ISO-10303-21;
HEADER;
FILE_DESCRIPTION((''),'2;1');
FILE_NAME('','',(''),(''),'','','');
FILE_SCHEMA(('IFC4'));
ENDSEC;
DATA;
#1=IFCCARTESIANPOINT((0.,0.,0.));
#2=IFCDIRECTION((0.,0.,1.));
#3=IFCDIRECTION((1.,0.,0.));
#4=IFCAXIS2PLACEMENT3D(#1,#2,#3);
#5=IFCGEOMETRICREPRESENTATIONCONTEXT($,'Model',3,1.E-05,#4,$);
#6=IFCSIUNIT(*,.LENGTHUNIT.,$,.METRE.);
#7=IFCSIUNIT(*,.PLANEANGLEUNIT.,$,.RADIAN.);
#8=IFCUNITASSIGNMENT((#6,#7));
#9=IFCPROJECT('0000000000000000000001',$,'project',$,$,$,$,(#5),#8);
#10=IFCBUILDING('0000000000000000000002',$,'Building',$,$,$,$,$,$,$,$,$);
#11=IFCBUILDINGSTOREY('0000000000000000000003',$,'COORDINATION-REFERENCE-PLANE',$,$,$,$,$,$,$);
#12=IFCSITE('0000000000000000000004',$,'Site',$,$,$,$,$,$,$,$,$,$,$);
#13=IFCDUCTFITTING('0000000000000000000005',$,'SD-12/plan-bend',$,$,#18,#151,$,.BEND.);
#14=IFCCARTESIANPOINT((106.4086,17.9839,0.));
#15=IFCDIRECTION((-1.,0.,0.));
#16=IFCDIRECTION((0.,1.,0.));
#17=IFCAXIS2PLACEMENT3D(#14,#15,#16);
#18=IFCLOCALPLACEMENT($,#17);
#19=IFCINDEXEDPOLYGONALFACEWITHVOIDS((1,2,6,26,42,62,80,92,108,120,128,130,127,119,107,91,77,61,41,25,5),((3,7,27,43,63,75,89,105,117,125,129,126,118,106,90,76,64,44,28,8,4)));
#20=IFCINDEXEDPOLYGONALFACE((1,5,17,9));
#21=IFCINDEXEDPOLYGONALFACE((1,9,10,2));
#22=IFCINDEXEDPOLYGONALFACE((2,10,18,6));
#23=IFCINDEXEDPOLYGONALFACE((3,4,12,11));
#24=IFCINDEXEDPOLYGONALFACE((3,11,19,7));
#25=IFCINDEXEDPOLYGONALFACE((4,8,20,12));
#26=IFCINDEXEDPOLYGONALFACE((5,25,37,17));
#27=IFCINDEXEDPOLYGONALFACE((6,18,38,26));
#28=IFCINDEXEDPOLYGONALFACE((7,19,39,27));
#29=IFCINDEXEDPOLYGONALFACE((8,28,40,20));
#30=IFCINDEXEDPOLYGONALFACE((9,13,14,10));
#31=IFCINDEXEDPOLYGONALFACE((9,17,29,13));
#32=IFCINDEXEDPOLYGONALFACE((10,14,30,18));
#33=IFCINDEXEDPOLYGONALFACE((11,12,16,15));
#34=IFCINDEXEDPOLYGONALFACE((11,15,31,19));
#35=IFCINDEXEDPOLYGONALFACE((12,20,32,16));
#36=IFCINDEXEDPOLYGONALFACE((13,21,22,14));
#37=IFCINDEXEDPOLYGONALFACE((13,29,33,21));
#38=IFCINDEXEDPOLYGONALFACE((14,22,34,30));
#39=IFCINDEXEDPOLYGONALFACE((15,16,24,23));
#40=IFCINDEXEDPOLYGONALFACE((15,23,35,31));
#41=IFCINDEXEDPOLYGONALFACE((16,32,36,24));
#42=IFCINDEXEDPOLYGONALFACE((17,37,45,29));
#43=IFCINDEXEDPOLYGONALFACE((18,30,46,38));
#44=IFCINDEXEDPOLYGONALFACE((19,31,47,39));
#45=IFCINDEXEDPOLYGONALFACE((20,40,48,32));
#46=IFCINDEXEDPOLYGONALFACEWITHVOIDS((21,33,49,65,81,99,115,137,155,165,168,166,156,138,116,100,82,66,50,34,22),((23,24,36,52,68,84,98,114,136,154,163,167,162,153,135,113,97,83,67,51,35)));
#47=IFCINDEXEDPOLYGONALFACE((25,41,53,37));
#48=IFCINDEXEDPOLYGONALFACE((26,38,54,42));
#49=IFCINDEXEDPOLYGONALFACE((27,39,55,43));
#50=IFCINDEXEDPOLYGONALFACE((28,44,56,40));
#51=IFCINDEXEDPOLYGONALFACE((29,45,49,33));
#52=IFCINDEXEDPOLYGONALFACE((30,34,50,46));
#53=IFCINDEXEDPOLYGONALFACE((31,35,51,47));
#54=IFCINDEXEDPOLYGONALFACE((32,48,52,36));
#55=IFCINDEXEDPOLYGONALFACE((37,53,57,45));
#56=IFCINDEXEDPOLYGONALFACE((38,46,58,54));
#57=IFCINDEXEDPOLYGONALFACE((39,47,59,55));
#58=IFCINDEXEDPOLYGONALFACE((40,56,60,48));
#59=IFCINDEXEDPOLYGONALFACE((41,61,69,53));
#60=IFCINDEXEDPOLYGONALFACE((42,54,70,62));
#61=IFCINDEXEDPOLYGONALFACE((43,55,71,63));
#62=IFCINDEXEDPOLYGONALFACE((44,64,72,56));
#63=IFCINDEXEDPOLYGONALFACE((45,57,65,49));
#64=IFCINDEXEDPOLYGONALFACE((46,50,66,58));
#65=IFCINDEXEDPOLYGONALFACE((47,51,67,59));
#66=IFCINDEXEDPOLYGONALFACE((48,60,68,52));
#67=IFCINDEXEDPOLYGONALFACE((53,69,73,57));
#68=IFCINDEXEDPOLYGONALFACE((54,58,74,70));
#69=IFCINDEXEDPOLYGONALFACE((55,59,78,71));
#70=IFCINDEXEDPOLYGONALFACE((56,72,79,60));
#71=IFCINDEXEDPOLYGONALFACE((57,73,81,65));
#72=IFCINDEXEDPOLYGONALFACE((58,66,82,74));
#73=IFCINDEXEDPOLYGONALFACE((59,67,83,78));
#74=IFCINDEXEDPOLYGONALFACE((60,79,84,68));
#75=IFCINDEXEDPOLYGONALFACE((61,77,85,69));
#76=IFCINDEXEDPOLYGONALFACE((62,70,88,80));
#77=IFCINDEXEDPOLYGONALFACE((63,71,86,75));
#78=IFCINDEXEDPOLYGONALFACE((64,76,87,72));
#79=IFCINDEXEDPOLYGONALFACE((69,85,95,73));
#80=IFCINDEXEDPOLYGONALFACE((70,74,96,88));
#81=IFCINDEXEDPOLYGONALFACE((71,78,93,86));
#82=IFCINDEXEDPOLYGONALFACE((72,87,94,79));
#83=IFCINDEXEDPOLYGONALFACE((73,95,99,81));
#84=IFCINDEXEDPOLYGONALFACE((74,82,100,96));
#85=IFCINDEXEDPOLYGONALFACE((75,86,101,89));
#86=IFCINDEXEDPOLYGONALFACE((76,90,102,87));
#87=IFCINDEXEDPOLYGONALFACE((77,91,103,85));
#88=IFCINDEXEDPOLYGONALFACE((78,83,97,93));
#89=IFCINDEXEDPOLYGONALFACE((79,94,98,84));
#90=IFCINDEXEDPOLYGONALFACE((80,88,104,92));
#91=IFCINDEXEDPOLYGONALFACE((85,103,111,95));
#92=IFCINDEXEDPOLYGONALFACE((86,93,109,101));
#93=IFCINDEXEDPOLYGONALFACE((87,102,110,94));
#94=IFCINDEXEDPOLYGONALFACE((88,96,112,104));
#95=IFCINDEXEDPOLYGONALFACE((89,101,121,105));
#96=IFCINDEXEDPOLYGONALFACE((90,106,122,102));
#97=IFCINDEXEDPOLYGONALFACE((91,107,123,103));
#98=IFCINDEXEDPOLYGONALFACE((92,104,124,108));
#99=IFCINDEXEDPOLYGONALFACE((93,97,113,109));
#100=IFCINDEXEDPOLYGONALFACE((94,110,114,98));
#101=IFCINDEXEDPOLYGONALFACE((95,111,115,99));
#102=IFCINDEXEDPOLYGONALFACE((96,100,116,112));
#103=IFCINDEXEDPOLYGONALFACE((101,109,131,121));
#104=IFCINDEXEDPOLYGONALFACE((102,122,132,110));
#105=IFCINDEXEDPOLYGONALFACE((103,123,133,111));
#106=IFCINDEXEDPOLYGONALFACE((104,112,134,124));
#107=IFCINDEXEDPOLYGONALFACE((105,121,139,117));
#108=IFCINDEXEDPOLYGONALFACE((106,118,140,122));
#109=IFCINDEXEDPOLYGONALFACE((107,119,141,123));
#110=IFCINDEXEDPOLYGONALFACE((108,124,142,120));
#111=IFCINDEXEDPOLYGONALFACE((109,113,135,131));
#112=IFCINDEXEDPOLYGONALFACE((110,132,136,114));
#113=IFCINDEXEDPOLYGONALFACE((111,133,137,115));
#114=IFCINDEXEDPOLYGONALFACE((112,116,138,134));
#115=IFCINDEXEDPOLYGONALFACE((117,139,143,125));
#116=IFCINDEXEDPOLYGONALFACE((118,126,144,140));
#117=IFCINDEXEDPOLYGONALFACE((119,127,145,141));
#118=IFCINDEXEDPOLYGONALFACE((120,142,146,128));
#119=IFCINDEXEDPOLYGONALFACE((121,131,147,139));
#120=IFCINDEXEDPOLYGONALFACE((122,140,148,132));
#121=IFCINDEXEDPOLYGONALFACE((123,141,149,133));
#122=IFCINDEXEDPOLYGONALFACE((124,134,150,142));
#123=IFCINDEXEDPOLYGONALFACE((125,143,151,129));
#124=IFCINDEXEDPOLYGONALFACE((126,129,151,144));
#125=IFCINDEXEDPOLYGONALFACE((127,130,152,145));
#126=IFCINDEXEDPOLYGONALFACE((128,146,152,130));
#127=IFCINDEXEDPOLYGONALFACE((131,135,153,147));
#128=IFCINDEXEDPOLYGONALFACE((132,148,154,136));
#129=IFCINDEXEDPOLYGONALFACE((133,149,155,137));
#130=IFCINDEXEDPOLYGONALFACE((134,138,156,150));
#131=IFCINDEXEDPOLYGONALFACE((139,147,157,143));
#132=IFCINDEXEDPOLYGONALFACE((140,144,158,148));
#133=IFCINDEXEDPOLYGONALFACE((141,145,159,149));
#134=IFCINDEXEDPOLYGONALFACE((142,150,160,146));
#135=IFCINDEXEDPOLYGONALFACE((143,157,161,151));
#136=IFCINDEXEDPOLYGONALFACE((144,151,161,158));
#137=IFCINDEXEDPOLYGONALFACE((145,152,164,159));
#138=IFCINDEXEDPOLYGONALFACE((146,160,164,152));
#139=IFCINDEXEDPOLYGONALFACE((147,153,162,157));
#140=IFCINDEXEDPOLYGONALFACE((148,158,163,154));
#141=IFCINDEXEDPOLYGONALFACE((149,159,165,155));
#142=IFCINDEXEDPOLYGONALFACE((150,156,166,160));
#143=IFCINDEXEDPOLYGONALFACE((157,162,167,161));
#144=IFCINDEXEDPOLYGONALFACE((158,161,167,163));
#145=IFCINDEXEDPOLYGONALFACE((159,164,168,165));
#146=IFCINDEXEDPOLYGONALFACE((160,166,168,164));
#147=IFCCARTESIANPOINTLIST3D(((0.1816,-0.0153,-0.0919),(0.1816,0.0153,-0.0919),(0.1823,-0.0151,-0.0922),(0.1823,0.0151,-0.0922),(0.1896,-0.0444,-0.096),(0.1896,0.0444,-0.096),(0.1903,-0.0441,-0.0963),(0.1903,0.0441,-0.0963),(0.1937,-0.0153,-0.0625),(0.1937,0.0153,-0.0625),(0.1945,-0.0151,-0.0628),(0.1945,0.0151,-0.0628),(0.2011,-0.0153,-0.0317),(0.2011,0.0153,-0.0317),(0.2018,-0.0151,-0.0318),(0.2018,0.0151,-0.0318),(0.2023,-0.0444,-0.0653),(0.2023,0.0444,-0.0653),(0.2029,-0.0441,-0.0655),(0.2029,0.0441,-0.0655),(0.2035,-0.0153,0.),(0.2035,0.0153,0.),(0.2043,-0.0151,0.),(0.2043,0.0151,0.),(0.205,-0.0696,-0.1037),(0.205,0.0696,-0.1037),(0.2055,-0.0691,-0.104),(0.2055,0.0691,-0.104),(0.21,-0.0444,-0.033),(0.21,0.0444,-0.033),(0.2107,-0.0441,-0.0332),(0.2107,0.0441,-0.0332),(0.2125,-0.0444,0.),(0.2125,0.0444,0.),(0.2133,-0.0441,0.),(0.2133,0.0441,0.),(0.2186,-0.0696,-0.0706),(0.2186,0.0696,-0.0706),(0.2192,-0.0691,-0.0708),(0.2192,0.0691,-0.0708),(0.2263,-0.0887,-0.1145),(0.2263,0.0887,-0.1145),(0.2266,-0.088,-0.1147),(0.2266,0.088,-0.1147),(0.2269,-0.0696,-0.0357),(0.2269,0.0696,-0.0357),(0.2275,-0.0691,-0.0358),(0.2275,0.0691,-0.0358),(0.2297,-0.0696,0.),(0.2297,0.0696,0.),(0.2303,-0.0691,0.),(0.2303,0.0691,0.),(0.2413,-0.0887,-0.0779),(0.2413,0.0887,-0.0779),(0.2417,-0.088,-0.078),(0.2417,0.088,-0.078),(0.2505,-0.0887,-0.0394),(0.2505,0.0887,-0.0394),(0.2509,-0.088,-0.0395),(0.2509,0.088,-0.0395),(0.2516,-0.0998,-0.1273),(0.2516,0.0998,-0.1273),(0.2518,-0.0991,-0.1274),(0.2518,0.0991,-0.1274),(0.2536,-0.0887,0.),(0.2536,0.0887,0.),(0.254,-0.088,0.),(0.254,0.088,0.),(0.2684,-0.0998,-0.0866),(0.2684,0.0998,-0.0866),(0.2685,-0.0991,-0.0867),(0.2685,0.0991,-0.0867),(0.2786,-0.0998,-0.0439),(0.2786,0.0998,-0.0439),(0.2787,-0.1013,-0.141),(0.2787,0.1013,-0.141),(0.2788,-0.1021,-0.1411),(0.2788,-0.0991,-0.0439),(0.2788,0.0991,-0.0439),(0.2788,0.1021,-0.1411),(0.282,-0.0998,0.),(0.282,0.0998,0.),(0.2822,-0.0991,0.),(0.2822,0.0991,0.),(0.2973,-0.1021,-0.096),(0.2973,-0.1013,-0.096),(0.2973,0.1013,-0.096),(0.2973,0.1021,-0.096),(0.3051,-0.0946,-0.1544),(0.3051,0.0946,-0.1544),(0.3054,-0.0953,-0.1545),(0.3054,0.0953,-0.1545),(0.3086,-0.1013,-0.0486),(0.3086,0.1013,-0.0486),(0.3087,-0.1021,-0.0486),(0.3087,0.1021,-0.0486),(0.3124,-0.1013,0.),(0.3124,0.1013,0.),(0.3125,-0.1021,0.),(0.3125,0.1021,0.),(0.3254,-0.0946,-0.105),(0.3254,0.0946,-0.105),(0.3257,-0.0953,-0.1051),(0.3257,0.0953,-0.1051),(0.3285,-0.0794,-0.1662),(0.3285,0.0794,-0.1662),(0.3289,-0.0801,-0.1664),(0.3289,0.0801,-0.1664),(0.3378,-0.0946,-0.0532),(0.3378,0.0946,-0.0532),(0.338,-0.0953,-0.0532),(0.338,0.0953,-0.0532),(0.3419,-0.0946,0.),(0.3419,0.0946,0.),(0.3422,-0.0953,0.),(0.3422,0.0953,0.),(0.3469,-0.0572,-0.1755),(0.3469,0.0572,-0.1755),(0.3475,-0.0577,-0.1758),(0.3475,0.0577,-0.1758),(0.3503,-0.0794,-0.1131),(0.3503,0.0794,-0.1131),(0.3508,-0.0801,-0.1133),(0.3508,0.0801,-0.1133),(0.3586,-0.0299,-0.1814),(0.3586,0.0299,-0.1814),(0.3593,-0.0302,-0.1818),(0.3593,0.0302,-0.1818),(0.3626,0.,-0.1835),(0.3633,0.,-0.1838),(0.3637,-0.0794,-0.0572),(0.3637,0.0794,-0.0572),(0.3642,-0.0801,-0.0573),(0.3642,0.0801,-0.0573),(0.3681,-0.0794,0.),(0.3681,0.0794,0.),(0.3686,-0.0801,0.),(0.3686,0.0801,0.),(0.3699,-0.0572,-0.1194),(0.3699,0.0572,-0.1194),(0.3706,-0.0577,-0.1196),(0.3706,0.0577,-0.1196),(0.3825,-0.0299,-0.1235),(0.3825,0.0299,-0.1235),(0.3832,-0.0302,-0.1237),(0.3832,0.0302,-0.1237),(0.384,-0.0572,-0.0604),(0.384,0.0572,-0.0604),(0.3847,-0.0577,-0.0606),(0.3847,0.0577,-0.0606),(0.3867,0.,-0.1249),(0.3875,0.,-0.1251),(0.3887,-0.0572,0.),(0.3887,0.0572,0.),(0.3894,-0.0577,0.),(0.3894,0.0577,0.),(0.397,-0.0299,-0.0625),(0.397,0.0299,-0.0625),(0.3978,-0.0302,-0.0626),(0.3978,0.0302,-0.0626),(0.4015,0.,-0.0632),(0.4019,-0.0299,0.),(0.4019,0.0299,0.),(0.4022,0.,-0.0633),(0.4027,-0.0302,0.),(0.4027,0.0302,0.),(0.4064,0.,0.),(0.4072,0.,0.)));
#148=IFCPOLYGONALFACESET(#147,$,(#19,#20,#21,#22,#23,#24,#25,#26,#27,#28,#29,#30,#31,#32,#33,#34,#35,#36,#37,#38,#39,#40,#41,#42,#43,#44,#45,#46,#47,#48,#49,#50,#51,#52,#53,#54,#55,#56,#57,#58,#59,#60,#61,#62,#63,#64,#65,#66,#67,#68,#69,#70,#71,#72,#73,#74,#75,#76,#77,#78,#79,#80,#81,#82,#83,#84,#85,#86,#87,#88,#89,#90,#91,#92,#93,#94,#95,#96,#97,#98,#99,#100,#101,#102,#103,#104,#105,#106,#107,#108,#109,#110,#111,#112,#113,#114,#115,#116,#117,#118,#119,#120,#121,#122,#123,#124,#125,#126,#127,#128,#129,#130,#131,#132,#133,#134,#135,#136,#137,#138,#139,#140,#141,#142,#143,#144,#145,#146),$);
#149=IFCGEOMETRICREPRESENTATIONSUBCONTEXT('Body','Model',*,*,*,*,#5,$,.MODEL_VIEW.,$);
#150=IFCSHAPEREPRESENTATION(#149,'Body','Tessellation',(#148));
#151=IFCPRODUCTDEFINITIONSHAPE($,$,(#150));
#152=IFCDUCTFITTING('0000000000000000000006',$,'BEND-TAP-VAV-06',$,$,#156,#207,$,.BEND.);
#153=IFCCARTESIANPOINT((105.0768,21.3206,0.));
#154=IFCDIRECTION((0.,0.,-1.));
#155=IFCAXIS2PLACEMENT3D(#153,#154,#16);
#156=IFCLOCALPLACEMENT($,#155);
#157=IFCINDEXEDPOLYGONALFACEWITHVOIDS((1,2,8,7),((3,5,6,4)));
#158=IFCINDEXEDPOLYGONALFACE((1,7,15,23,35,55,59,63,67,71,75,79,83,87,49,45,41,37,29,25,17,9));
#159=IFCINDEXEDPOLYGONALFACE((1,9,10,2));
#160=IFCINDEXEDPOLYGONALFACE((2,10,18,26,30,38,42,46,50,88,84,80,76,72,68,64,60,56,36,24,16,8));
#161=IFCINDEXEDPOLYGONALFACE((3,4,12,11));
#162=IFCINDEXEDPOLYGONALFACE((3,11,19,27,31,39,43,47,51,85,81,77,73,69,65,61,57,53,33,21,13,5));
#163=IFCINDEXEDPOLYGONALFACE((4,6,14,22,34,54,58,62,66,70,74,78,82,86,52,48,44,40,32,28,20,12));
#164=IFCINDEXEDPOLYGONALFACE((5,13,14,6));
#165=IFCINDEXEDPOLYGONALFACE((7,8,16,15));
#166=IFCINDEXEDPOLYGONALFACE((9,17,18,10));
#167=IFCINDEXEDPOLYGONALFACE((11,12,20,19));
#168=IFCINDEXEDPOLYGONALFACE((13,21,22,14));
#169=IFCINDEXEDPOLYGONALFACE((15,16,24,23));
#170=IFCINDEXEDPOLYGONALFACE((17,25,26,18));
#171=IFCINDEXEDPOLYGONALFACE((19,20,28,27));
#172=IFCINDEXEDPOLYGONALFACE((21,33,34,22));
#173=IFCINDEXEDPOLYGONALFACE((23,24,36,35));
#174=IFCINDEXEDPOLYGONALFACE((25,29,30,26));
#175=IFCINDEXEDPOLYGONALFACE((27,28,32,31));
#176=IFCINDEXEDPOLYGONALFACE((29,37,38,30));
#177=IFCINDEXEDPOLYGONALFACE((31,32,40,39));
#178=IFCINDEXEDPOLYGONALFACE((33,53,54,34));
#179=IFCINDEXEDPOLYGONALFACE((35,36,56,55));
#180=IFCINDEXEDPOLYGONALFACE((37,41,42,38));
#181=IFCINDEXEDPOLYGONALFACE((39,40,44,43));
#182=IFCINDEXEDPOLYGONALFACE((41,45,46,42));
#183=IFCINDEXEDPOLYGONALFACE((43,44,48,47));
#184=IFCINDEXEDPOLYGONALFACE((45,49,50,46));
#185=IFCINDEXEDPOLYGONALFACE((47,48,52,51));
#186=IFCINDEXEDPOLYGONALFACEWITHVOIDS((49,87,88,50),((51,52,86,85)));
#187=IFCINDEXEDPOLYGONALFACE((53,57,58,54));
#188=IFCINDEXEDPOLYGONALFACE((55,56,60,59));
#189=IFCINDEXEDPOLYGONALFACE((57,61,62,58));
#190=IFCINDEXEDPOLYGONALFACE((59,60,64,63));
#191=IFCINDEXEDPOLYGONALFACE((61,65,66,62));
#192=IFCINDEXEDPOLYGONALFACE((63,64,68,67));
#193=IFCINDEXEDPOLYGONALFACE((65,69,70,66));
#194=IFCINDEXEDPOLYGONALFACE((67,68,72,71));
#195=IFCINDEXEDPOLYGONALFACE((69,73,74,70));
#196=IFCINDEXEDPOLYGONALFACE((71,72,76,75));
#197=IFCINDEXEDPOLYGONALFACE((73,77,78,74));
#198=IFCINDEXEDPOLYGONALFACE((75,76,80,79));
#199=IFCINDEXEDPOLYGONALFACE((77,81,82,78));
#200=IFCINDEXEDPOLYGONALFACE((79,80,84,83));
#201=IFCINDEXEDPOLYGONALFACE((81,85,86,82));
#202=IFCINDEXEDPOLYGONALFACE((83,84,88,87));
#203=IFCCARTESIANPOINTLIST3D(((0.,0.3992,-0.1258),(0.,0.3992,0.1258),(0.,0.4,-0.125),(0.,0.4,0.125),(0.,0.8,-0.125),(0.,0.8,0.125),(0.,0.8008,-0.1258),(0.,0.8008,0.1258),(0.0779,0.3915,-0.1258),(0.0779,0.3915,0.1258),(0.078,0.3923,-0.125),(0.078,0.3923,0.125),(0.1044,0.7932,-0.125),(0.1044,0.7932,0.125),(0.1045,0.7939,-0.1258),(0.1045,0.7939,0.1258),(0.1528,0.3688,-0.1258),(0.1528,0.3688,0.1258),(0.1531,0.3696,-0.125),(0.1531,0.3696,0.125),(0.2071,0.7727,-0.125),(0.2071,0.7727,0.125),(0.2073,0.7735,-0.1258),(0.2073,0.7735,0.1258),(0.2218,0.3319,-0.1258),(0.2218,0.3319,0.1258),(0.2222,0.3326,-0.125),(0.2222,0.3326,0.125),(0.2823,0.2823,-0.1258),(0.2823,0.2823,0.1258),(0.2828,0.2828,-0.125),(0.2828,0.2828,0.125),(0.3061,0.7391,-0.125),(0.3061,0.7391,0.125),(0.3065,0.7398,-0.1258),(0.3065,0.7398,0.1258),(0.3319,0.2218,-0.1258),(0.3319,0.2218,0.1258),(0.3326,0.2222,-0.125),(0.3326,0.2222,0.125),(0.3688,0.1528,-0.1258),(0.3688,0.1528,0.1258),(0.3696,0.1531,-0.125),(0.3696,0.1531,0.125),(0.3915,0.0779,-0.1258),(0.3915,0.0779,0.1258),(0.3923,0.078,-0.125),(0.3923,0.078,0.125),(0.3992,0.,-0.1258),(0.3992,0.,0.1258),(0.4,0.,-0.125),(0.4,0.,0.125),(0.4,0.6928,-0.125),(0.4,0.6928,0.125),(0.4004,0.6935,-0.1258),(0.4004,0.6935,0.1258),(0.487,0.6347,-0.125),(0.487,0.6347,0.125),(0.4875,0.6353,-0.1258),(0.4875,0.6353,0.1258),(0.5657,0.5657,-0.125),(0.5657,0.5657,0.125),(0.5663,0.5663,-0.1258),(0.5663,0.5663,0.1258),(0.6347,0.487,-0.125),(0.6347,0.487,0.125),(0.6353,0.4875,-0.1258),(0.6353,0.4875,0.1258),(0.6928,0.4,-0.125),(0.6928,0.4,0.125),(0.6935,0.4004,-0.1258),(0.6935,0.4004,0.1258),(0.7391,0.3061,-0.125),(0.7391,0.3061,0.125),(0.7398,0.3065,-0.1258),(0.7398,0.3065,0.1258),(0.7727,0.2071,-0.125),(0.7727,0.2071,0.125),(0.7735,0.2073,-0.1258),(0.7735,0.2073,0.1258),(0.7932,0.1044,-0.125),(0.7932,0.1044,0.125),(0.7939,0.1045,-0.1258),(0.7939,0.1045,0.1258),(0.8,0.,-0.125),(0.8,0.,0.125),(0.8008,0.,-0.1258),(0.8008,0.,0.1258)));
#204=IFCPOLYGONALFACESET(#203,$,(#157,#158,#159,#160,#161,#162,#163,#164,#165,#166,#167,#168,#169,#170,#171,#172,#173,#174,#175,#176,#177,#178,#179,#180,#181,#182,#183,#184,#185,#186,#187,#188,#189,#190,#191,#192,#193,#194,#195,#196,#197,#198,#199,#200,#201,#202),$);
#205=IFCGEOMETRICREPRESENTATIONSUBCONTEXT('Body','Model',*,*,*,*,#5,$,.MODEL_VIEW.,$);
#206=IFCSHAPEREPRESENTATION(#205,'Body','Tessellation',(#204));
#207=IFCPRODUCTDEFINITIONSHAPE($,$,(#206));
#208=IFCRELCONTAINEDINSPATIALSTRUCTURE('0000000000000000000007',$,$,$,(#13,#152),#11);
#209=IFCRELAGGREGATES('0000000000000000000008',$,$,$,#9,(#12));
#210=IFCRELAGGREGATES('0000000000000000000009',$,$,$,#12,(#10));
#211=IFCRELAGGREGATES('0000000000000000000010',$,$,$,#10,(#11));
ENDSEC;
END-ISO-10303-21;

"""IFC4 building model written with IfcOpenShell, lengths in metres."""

from ifc_helpers import new_model, entity, si_unit, frame, origin_with_axes, place, context, subcontext, project, spatial, element, save


model = new_model("IFC4")

# Units and contexts
model_context_1 = context("Model", 3, precision=1e-05, world=origin_with_axes())
body_context_1 = subcontext(model_context_1, "Body", "Model", "MODEL_VIEW")
body_context_2 = subcontext(model_context_1, "Body", "Model", "MODEL_VIEW")
ifc_project = project(units=[si_unit("LENGTHUNIT", "METRE"), si_unit("PLANEANGLEUNIT", "RADIAN")], contexts=[model_context_1])

# Site, building, storey
site = spatial("IfcSite", under=ifc_project, Name="Site")
building = spatial("IfcBuilding", under=site, Name="Building")
storey = spatial("IfcBuildingStorey", under=building, Name="COORDINATION-REFERENCE-PLANE")

# Duct fitting
duct_fitting_1_placement = place(None, frame((106.4086, 17.9839, 0.0), z_axis=(-1.0, 0.0, 0.0), x_axis=(0.0, 1.0, 0.0)))
element("IfcDuctFitting", 1, at=duct_fitting_1_placement, inside=storey, Name="SD-12/plan-bend", PredefinedType="BEND", context=body_context_1, shape_type="SweptSolid", body=[
    entity("IfcRevolvedAreaSolid", entity("IfcCircleHollowProfileDef", "AREA", None, entity("IfcAxis2Placement2D", entity("IfcCartesianPoint", [0.3048, 0.0])), 0.1024, 0.0008), entity("IfcAxis2Placement3D", entity("IfcCartesianPoint", [0.0, 0.0, 0.0]), entity("IfcDirection", [0.0, 0.0, 1.0]), entity("IfcDirection", [1.0, 0.0, 0.0])), entity("IfcAxis1Placement", entity("IfcCartesianPoint", [0.0, 0.0, 0.0]), entity("IfcDirection", [0.0, 1.0, 0.0])), 0.468399),
])

# Duct fitting
duct_fitting_2_placement = place(None, frame((105.0768, 21.3206, 0.0), z_axis=(0.0, 0.0, -1.0), x_axis=(0.0, 1.0, 0.0)))
cartesian_point = entity("IfcCartesianPoint", [0.0, 0.0, 0.0])
element("IfcDuctFitting", 2, at=duct_fitting_2_placement, inside=storey, Name="BEND-TAP-VAV-06", PredefinedType="BEND", context=body_context_2, shape_type="SweptSolid", body=[
    entity("IfcRevolvedAreaSolid", entity("IfcRectangleHollowProfileDef", "AREA", None, entity("IfcAxis2Placement2D", entity("IfcCartesianPoint", [0.6, 0.0])), 0.4016, 0.2516, 0.0008), entity("IfcAxis2Placement3D", cartesian_point, entity("IfcDirection", [0.0, -1.0, 0.0]), entity("IfcDirection", [1.0, 0.0, 0.0])), entity("IfcAxis1Placement", cartesian_point, entity("IfcDirection", [0.0, 1.0, 0.0])), 1.570796),
])

save(model, "model.ifc")
